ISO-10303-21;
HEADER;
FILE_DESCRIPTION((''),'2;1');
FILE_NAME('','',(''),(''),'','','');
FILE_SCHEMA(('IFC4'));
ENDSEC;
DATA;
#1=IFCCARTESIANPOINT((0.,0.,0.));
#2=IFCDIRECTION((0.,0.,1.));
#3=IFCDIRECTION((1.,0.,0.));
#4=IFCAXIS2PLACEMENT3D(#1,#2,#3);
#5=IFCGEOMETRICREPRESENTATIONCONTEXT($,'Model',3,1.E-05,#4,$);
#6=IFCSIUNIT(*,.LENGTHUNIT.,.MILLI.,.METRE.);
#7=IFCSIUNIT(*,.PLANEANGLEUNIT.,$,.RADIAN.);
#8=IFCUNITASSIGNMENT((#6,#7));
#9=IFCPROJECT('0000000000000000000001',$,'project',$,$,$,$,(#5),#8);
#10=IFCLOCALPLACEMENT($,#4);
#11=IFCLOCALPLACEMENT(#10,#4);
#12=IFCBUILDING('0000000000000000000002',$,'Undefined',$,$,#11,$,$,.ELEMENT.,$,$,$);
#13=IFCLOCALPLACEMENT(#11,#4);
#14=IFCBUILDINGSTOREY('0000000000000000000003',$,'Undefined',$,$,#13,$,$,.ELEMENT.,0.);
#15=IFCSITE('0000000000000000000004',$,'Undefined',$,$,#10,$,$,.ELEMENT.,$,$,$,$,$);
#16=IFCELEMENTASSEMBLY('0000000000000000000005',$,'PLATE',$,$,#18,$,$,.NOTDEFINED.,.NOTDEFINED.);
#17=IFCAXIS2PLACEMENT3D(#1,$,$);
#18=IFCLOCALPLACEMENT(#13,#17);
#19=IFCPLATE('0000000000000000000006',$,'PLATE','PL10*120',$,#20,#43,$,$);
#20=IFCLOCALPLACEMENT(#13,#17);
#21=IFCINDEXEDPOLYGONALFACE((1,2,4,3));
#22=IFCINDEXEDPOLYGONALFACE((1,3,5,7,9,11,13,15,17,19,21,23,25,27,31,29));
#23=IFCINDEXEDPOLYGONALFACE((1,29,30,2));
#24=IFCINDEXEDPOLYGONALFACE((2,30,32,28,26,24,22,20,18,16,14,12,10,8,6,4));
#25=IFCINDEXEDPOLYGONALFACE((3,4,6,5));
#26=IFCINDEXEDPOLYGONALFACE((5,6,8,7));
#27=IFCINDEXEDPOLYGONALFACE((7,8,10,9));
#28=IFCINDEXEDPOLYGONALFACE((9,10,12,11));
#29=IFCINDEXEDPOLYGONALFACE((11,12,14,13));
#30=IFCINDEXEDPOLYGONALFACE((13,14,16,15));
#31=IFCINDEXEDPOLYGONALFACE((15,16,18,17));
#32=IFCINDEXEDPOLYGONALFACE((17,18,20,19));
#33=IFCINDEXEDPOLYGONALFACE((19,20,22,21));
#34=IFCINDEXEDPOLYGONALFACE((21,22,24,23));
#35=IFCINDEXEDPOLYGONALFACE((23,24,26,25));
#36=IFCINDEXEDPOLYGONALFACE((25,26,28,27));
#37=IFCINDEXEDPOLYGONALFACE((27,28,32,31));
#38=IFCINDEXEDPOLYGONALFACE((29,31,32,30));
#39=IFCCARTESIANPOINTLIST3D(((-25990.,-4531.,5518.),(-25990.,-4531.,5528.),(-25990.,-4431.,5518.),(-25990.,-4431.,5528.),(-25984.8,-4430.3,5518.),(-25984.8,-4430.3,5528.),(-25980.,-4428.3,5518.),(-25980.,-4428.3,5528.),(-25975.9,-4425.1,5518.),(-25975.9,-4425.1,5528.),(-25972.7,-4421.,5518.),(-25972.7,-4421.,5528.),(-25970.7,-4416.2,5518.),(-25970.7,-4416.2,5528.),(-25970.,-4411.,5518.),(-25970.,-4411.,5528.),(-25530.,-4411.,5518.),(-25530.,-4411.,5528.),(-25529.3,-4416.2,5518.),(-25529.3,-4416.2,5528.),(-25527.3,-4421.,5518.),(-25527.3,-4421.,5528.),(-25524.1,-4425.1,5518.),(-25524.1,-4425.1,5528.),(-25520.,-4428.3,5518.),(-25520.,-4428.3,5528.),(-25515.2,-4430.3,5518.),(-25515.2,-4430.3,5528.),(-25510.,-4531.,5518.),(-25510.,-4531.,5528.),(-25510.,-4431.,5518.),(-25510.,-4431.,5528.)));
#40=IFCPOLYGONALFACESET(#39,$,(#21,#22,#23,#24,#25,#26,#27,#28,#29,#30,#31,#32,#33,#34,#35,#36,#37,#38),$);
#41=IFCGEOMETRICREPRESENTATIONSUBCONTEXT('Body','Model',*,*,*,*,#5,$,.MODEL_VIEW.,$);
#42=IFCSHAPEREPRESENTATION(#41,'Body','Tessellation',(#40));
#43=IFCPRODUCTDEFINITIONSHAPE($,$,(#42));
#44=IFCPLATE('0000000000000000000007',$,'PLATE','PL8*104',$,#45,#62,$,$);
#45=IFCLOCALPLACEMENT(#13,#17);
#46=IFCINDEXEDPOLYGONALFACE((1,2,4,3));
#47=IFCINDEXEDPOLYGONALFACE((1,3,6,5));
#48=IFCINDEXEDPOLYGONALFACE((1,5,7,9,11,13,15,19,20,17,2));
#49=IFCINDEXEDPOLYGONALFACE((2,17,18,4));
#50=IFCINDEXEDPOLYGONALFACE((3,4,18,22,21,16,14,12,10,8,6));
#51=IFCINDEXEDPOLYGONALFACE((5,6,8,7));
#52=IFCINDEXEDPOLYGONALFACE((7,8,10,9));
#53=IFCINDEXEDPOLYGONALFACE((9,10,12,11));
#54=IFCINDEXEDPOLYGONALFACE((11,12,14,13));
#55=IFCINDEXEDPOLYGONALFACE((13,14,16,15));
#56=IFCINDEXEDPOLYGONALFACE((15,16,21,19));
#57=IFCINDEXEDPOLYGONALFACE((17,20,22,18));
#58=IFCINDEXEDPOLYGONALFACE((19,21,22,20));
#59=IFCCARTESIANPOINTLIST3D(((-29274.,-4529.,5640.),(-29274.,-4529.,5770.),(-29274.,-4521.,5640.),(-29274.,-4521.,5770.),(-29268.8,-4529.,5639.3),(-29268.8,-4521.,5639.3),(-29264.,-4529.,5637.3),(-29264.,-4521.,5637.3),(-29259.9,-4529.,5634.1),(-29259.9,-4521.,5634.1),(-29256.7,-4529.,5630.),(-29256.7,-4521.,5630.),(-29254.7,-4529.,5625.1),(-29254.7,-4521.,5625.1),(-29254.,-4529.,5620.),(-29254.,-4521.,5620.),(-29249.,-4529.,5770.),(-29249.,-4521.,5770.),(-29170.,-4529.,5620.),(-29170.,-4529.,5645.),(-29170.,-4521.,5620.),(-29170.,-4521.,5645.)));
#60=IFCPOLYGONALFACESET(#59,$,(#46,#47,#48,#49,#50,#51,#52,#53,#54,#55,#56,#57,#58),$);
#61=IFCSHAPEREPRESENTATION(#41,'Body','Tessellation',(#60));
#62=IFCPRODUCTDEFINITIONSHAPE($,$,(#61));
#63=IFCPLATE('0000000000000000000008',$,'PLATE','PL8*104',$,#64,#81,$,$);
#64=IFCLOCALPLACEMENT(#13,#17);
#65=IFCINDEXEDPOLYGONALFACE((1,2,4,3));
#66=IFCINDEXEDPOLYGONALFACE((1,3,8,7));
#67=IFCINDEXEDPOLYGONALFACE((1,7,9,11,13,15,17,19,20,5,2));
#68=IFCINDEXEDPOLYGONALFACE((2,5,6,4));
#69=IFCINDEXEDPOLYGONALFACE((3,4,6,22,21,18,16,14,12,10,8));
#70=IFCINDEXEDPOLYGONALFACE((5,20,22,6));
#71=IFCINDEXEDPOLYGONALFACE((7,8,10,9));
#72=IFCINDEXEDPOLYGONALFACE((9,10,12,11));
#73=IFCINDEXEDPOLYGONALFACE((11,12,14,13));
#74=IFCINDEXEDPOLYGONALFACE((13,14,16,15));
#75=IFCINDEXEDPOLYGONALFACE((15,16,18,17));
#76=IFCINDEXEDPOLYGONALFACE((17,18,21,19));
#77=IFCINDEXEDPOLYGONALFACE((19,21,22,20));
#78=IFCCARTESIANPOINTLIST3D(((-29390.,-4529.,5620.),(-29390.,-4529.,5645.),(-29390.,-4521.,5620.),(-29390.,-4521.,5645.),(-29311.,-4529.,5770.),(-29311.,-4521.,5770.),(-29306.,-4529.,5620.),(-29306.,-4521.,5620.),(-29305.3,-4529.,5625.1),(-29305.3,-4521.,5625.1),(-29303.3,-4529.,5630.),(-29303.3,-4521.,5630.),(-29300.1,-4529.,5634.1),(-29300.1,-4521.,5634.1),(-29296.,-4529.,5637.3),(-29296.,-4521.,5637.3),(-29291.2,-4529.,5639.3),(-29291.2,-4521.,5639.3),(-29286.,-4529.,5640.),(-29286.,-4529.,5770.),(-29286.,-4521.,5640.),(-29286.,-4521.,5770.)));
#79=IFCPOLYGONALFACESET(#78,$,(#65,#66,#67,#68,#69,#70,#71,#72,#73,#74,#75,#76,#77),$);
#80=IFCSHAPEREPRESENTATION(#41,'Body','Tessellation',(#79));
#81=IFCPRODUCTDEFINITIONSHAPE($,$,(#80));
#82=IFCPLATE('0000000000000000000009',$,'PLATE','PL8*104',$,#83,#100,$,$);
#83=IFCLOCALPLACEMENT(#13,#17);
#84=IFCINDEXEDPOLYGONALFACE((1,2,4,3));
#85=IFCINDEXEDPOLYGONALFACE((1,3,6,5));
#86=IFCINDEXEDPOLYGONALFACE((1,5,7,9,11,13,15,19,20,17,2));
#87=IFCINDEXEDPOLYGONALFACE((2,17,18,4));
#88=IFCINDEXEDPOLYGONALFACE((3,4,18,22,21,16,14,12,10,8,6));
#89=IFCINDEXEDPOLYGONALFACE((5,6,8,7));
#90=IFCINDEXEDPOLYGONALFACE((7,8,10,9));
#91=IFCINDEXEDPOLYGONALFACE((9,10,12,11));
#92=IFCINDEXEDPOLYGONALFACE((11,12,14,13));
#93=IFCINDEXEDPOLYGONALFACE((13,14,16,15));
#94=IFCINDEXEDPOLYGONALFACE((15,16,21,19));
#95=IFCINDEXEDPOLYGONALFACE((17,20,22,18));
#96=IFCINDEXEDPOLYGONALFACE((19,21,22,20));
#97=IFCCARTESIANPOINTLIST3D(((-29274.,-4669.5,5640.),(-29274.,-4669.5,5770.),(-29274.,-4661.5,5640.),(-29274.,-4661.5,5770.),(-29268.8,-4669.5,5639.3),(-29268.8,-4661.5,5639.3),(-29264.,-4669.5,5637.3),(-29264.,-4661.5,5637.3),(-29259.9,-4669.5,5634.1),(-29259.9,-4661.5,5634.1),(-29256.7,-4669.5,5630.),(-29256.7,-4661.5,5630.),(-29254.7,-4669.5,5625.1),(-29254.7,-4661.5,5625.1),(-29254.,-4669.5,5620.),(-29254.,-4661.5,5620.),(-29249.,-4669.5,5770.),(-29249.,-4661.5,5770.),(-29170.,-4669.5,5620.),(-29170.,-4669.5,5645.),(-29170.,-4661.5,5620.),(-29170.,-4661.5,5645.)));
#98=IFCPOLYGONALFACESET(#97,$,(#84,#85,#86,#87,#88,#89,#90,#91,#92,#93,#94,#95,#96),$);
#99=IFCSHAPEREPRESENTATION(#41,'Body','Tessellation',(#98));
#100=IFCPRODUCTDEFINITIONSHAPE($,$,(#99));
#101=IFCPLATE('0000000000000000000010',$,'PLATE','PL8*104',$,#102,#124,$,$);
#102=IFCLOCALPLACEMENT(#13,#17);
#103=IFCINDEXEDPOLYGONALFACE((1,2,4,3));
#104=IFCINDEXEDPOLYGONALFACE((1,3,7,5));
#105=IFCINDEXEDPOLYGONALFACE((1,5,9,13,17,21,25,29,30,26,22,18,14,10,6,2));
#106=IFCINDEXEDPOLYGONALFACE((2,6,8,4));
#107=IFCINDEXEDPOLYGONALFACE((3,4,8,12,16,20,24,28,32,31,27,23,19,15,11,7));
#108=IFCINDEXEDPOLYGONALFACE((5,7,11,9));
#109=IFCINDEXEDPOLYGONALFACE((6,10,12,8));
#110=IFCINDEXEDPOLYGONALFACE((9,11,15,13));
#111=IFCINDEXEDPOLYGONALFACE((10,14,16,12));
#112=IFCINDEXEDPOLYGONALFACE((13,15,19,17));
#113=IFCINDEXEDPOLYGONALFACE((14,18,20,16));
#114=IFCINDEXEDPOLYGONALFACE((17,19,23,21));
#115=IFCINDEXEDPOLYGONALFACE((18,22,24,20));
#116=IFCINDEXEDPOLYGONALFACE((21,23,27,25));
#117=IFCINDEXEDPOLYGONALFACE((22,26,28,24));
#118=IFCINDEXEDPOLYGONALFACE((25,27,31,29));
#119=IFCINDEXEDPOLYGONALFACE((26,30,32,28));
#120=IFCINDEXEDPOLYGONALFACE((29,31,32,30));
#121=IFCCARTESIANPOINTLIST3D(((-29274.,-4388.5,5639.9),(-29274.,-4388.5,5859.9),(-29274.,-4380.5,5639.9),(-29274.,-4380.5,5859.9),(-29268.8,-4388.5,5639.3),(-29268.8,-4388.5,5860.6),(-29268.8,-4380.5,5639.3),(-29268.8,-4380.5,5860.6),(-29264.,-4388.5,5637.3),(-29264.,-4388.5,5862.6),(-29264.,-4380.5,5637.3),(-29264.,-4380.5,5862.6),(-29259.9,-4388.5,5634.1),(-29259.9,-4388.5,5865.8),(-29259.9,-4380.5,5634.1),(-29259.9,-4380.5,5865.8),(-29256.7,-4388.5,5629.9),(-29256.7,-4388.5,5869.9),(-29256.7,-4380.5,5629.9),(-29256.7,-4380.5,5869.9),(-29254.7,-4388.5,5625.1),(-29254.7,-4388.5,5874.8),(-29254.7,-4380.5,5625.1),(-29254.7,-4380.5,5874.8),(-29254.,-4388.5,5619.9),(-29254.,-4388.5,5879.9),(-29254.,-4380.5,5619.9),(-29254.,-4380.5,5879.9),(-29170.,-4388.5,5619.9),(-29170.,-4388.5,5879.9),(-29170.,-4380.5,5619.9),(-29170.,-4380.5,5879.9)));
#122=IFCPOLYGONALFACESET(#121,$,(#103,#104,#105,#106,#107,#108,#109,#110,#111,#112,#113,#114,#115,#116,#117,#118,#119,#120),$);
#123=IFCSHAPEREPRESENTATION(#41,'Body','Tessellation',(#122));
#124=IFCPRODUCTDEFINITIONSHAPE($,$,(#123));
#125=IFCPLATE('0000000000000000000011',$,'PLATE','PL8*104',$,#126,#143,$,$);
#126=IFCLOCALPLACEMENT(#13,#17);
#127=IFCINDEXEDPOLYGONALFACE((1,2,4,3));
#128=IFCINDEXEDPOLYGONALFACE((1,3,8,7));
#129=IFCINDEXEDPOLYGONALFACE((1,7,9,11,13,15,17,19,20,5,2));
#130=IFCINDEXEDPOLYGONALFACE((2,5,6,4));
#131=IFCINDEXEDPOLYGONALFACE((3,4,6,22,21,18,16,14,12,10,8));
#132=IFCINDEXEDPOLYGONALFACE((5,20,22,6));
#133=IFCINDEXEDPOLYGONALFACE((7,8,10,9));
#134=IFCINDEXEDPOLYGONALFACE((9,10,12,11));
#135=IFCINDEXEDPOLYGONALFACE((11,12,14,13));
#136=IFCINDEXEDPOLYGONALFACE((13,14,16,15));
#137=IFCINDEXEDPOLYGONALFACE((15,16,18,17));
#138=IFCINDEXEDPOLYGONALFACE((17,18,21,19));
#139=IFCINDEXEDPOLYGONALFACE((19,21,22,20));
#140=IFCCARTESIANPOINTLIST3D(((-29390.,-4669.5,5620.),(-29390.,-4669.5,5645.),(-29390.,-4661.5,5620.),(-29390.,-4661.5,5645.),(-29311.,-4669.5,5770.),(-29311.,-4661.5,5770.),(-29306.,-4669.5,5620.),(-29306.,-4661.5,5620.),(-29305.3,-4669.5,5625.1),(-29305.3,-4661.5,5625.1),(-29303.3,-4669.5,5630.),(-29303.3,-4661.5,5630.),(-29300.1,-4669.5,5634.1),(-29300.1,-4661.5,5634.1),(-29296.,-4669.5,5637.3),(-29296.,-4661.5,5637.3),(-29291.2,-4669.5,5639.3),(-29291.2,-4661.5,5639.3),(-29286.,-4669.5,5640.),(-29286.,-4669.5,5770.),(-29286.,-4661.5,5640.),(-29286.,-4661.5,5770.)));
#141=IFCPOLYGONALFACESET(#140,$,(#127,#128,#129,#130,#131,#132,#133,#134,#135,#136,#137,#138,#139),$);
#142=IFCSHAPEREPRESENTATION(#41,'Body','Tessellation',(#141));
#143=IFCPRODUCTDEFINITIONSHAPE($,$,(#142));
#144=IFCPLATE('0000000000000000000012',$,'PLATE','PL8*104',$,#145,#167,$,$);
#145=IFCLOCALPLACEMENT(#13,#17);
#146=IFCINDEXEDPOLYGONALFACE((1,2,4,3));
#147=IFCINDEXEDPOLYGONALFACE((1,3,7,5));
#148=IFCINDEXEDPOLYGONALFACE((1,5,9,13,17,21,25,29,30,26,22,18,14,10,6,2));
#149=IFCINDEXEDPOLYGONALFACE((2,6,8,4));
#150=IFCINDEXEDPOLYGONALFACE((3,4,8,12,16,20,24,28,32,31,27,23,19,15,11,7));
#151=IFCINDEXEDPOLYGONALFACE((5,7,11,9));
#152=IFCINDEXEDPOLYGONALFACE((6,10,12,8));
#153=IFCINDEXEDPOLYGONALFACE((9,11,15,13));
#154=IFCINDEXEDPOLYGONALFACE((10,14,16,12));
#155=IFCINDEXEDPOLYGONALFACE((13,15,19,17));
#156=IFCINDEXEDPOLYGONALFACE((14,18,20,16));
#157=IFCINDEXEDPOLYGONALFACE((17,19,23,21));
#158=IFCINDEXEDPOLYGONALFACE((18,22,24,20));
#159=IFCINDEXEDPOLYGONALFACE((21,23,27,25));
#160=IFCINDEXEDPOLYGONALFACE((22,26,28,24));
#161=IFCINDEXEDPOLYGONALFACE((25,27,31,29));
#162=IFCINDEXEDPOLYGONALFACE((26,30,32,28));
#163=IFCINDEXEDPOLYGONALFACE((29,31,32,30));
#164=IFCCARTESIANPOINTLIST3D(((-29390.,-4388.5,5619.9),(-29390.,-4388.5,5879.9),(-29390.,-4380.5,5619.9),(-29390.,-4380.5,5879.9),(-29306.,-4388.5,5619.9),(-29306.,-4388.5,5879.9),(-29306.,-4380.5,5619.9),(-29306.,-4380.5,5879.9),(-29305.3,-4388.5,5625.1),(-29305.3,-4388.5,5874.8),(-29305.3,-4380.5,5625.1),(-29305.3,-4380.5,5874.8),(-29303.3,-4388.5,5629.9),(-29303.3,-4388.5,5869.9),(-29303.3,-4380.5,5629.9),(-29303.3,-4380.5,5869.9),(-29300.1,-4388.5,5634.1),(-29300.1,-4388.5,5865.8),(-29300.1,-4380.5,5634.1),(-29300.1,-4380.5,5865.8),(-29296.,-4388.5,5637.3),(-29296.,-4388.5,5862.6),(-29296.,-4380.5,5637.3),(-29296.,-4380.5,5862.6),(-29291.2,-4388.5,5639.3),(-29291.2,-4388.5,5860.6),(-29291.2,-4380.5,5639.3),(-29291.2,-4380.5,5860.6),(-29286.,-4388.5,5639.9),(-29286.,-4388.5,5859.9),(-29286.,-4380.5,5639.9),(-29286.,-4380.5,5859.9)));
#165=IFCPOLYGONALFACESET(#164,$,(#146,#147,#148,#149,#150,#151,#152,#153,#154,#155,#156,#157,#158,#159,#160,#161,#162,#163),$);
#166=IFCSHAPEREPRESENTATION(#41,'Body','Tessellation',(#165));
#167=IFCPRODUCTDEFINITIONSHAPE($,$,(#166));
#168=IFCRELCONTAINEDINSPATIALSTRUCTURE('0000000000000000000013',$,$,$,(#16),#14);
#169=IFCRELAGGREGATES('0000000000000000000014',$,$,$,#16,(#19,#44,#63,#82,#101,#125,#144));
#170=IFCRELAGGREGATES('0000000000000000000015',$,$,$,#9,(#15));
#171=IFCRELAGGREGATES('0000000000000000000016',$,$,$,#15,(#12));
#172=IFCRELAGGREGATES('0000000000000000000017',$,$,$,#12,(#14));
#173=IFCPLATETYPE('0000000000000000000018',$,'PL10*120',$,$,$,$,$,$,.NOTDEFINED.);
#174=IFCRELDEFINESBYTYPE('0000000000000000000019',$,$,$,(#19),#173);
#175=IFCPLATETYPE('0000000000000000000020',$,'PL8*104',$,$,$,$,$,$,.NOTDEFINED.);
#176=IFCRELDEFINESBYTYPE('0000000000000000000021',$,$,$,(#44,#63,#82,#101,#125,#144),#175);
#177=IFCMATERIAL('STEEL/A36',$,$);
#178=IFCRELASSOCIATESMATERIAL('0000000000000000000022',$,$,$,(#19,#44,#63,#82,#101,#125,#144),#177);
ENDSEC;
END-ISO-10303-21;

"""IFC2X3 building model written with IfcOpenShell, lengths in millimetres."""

from ifc_helpers import new_model, si_unit, frame, frame_2d, origin_with_axes, place, context, subcontext, project, spatial, polyline, circle_curve, parameter, trimmed, segment, composite_curve, outline, extrude, material, type_object, element, aggregate, save


model = new_model("IFC2X3")

# Units and contexts
model_context = context("Model", 3, precision=1e-05, world=origin_with_axes())
body_context = subcontext(model_context, "Body", "Model", "MODEL_VIEW")
ifc_project = project(units=[si_unit("LENGTHUNIT", "METRE", prefix="MILLI"), si_unit("PLANEANGLEUNIT", "RADIAN")], contexts=[model_context])

# Site, building, storey
site_placement = place(None, origin_with_axes())
site = spatial("IfcSite", under=ifc_project, at=site_placement, Name="Undefined", CompositionType="ELEMENT")
building_placement = place(site_placement, origin_with_axes())
building = spatial("IfcBuilding", under=site, at=building_placement, Name="Undefined", CompositionType="ELEMENT")
storey_placement = place(building_placement, origin_with_axes())
storey = spatial("IfcBuildingStorey", under=building, at=storey_placement, Name="Undefined", CompositionType="ELEMENT", Elevation=0.0)

# Element assembly, plates
assembly_1_placement = place(storey_placement, origin_with_axes())
assembly_1 = element("IfcElementAssembly", 1, at=assembly_1_placement, inside=storey, Name="PLATE", AssemblyPlace="NOTDEFINED", PredefinedType="NOTDEFINED")
ifc_material_1 = material(Name="STEEL/A36")
plate_type_1 = type_object("IfcPlateType", Name="PL10*120", PredefinedType="NOTDEFINED")
plate_1_placement = place(assembly_1_placement, frame((-25510.0, -4531.0, 5523.0), z_axis=(0.0, 0.0, -1.0), x_axis=(-1.0, 0.0, 0.0)))
plate_1 = element("IfcPlate", 2, at=plate_1_placement, type_object=plate_type_1, material=ifc_material_1, Name="PLATE", Description="PL10*120", context=body_context, shape_type="SweptSolid", body=[
    extrude(outline(composite_curve([segment(polyline([(0.0, 0.0), (480.0, 0.0), (480.0, 100.0)]), True, "CONTINUOUS"), segment(trimmed(circle_curve(frame_2d((480.0, 120.0), x_axis=(-0.000015, -1.0)), 20.0), [parameter(0.0)], [parameter(4.712402)], False, "PARAMETER"), True, "CONTINUOUS"), segment(polyline([(460.0, 120.0), (20.0, 120.0)]), True, "CONTINUOUS"), segment(trimmed(circle_curve(frame_2d((0.0, 120.0), x_axis=(1.0, -0.000002)), 20.0), [parameter(0.0)], [parameter(4.712393)], False, "PARAMETER"), True, "CONTINUOUS"), segment(polyline([(0.0, 100.0), (0.0, 0.0)]), True, "CONTINUOUS")], self_intersect=True)), frame((0.0, 0.0, -5.0), z_axis=(0.0, 0.0, 1.0), x_axis=(1.0, 0.0, 0.0)), (0.0, 0.0, 1.0), 10.0),
])
plate_type_2 = type_object("IfcPlateType", Name="PL8*104", PredefinedType="NOTDEFINED")
plate_2_placement = place(assembly_1_placement, frame((-29274.0, -4525.0, 5620.0), z_axis=(0.0, 1.0, 0.0), x_axis=(0.0, 0.0, 1.0)))
plate_2 = element("IfcPlate", 3, at=plate_2_placement, type_object=plate_type_2, material=ifc_material_1, Name="PLATE", Description="PL8*104", context=body_context, shape_type="SweptSolid", body=[
    extrude(outline(composite_curve([segment(trimmed(circle_curve(frame_2d((0.0, 0.0), x_axis=(0.000147, 1.0)), 20.0), [parameter(0.0)], [parameter(4.712536)], False, "PARAMETER"), True, "CONTINUOUS"), segment(polyline([(20.0, 0.0), (150.0, 0.0), (150.0, 25.0), (25.0, 104.0), (0.0, 104.0), (0.0, 20.0)]), True, "CONTINUOUS")], self_intersect=True)), frame((0.0, 0.0, -4.0), z_axis=(0.0, 0.0, 1.0), x_axis=(1.0, 0.0, 0.0)), (0.0, 0.0, 1.0), 8.0),
])
plate_3_placement = place(assembly_1_placement, frame((-29286.0, -4525.0, 5620.0), z_axis=(0.0, -1.0, 0.0), x_axis=(0.0, 0.0, 1.0)))
plate_3 = element("IfcPlate", 4, at=plate_3_placement, type_object=plate_type_2, material=ifc_material_1, Name="PLATE", Description="PL8*104", context=body_context, shape_type="SweptSolid", body=[
    extrude(outline(composite_curve([segment(trimmed(circle_curve(frame_2d((0.0, 0.0), x_axis=(0.000147, 1.0)), 20.0), [parameter(0.0)], [parameter(4.712536)], False, "PARAMETER"), True, "CONTINUOUS"), segment(polyline([(20.0, 0.0), (150.0, 0.0), (150.0, 25.0), (25.0, 104.0), (0.0, 104.0), (0.0, 20.0)]), True, "CONTINUOUS")], self_intersect=True)), frame((0.0, 0.0, -4.0), z_axis=(0.0, 0.0, 1.0), x_axis=(1.0, 0.0, 0.0)), (0.0, 0.0, 1.0), 8.0),
])
plate_4_placement = place(assembly_1_placement, frame((-29274.0, -4665.5, 5620.0), z_axis=(0.0, 1.0, 0.0), x_axis=(0.0, 0.0, 1.0)))
plate_4 = element("IfcPlate", 5, at=plate_4_placement, type_object=plate_type_2, material=ifc_material_1, Name="PLATE", Description="PL8*104", context=body_context, shape_type="SweptSolid", body=[
    extrude(outline(composite_curve([segment(trimmed(circle_curve(frame_2d((0.0, 0.0), x_axis=(0.000147, 1.0)), 20.0), [parameter(0.0)], [parameter(4.712536)], False, "PARAMETER"), True, "CONTINUOUS"), segment(polyline([(20.0, 0.0), (150.0, 0.0), (150.0, 25.0), (25.0, 104.0), (0.0, 104.0), (0.0, 20.0)]), True, "CONTINUOUS")], self_intersect=True)), frame((0.0, 0.0, -4.0), z_axis=(0.0, 0.0, 1.0), x_axis=(1.0, 0.0, 0.0)), (0.0, 0.0, 1.0), 8.0),
])
plate_5_placement = place(assembly_1_placement, frame((-29170.0, -4384.5, 5879.9), z_axis=(0.0, 1.0, 0.0), x_axis=(0.0, 0.0, -1.0)))
plate_5 = element("IfcPlate", 6, at=plate_5_placement, type_object=plate_type_2, material=ifc_material_1, Name="PLATE", Description="PL8*104", context=body_context, shape_type="SweptSolid", body=[
    extrude(outline(composite_curve([segment(polyline([(0.0, 0.0), (260.0, 0.0), (260.0, 84.0)]), True, "CONTINUOUS"), segment(trimmed(circle_curve(frame_2d((260.0, 104.0), x_axis=(-0.000002, -1.0)), 20.0), [parameter(0.0)], [parameter(4.712391)], False, "PARAMETER"), True, "CONTINUOUS"), segment(polyline([(240.0, 104.0), (20.0, 104.0)]), True, "CONTINUOUS"), segment(trimmed(circle_curve(frame_2d((0.0, 104.0), x_axis=(1.0, 0.0)), 20.0), [parameter(0.0)], [parameter(4.712389)], False, "PARAMETER"), True, "CONTINUOUS"), segment(polyline([(0.0, 84.0), (0.0, 0.0)]), True, "CONTINUOUS")], self_intersect=True)), frame((0.0, 0.0, -4.0), z_axis=(0.0, 0.0, 1.0), x_axis=(1.0, 0.0, 0.0)), (0.0, 0.0, 1.0), 8.0),
])
plate_6_placement = place(assembly_1_placement, frame((-29286.0, -4665.5, 5620.0), z_axis=(0.0, -1.0, 0.0), x_axis=(0.0, 0.0, 1.0)))
plate_6 = element("IfcPlate", 7, at=plate_6_placement, type_object=plate_type_2, material=ifc_material_1, Name="PLATE", Description="PL8*104", context=body_context, shape_type="SweptSolid", body=[
    extrude(outline(composite_curve([segment(trimmed(circle_curve(frame_2d((0.0, 0.0), x_axis=(0.000147, 1.0)), 20.0), [parameter(0.0)], [parameter(4.712536)], False, "PARAMETER"), True, "CONTINUOUS"), segment(polyline([(20.0, 0.0), (150.0, 0.0), (150.0, 25.0), (25.0, 104.0), (0.0, 104.0), (0.0, 20.0)]), True, "CONTINUOUS")], self_intersect=True)), frame((0.0, 0.0, -4.0), z_axis=(0.0, 0.0, 1.0), x_axis=(1.0, 0.0, 0.0)), (0.0, 0.0, 1.0), 8.0),
])
plate_7_placement = place(assembly_1_placement, frame((-29390.0, -4384.5, 5879.9), z_axis=(0.0, -1.0, 0.0), x_axis=(0.0, 0.0, -1.0)))
plate_7 = element("IfcPlate", 8, at=plate_7_placement, type_object=plate_type_2, material=ifc_material_1, Name="PLATE", Description="PL8*104", context=body_context, shape_type="SweptSolid", body=[
    extrude(outline(composite_curve([segment(polyline([(0.0, 0.0), (260.0, 0.0), (260.0, 84.0)]), True, "CONTINUOUS"), segment(trimmed(circle_curve(frame_2d((260.0, 104.0), x_axis=(-0.000002, -1.0)), 20.0), [parameter(0.0)], [parameter(4.712391)], False, "PARAMETER"), True, "CONTINUOUS"), segment(polyline([(240.0, 104.0), (20.0, 104.0)]), True, "CONTINUOUS"), segment(trimmed(circle_curve(frame_2d((0.0, 104.0), x_axis=(1.0, 0.0)), 20.0), [parameter(0.0)], [parameter(4.712389)], False, "PARAMETER"), True, "CONTINUOUS"), segment(polyline([(0.0, 84.0), (0.0, 0.0)]), True, "CONTINUOUS")], self_intersect=True)), frame((0.0, 0.0, -4.0), z_axis=(0.0, 0.0, 1.0), x_axis=(1.0, 0.0, 0.0)), (0.0, 0.0, 1.0), 8.0),
])

aggregate(assembly_1, [plate_1, plate_2, plate_3, plate_4, plate_5, plate_6, plate_7])

save(model, "model.ifc")
